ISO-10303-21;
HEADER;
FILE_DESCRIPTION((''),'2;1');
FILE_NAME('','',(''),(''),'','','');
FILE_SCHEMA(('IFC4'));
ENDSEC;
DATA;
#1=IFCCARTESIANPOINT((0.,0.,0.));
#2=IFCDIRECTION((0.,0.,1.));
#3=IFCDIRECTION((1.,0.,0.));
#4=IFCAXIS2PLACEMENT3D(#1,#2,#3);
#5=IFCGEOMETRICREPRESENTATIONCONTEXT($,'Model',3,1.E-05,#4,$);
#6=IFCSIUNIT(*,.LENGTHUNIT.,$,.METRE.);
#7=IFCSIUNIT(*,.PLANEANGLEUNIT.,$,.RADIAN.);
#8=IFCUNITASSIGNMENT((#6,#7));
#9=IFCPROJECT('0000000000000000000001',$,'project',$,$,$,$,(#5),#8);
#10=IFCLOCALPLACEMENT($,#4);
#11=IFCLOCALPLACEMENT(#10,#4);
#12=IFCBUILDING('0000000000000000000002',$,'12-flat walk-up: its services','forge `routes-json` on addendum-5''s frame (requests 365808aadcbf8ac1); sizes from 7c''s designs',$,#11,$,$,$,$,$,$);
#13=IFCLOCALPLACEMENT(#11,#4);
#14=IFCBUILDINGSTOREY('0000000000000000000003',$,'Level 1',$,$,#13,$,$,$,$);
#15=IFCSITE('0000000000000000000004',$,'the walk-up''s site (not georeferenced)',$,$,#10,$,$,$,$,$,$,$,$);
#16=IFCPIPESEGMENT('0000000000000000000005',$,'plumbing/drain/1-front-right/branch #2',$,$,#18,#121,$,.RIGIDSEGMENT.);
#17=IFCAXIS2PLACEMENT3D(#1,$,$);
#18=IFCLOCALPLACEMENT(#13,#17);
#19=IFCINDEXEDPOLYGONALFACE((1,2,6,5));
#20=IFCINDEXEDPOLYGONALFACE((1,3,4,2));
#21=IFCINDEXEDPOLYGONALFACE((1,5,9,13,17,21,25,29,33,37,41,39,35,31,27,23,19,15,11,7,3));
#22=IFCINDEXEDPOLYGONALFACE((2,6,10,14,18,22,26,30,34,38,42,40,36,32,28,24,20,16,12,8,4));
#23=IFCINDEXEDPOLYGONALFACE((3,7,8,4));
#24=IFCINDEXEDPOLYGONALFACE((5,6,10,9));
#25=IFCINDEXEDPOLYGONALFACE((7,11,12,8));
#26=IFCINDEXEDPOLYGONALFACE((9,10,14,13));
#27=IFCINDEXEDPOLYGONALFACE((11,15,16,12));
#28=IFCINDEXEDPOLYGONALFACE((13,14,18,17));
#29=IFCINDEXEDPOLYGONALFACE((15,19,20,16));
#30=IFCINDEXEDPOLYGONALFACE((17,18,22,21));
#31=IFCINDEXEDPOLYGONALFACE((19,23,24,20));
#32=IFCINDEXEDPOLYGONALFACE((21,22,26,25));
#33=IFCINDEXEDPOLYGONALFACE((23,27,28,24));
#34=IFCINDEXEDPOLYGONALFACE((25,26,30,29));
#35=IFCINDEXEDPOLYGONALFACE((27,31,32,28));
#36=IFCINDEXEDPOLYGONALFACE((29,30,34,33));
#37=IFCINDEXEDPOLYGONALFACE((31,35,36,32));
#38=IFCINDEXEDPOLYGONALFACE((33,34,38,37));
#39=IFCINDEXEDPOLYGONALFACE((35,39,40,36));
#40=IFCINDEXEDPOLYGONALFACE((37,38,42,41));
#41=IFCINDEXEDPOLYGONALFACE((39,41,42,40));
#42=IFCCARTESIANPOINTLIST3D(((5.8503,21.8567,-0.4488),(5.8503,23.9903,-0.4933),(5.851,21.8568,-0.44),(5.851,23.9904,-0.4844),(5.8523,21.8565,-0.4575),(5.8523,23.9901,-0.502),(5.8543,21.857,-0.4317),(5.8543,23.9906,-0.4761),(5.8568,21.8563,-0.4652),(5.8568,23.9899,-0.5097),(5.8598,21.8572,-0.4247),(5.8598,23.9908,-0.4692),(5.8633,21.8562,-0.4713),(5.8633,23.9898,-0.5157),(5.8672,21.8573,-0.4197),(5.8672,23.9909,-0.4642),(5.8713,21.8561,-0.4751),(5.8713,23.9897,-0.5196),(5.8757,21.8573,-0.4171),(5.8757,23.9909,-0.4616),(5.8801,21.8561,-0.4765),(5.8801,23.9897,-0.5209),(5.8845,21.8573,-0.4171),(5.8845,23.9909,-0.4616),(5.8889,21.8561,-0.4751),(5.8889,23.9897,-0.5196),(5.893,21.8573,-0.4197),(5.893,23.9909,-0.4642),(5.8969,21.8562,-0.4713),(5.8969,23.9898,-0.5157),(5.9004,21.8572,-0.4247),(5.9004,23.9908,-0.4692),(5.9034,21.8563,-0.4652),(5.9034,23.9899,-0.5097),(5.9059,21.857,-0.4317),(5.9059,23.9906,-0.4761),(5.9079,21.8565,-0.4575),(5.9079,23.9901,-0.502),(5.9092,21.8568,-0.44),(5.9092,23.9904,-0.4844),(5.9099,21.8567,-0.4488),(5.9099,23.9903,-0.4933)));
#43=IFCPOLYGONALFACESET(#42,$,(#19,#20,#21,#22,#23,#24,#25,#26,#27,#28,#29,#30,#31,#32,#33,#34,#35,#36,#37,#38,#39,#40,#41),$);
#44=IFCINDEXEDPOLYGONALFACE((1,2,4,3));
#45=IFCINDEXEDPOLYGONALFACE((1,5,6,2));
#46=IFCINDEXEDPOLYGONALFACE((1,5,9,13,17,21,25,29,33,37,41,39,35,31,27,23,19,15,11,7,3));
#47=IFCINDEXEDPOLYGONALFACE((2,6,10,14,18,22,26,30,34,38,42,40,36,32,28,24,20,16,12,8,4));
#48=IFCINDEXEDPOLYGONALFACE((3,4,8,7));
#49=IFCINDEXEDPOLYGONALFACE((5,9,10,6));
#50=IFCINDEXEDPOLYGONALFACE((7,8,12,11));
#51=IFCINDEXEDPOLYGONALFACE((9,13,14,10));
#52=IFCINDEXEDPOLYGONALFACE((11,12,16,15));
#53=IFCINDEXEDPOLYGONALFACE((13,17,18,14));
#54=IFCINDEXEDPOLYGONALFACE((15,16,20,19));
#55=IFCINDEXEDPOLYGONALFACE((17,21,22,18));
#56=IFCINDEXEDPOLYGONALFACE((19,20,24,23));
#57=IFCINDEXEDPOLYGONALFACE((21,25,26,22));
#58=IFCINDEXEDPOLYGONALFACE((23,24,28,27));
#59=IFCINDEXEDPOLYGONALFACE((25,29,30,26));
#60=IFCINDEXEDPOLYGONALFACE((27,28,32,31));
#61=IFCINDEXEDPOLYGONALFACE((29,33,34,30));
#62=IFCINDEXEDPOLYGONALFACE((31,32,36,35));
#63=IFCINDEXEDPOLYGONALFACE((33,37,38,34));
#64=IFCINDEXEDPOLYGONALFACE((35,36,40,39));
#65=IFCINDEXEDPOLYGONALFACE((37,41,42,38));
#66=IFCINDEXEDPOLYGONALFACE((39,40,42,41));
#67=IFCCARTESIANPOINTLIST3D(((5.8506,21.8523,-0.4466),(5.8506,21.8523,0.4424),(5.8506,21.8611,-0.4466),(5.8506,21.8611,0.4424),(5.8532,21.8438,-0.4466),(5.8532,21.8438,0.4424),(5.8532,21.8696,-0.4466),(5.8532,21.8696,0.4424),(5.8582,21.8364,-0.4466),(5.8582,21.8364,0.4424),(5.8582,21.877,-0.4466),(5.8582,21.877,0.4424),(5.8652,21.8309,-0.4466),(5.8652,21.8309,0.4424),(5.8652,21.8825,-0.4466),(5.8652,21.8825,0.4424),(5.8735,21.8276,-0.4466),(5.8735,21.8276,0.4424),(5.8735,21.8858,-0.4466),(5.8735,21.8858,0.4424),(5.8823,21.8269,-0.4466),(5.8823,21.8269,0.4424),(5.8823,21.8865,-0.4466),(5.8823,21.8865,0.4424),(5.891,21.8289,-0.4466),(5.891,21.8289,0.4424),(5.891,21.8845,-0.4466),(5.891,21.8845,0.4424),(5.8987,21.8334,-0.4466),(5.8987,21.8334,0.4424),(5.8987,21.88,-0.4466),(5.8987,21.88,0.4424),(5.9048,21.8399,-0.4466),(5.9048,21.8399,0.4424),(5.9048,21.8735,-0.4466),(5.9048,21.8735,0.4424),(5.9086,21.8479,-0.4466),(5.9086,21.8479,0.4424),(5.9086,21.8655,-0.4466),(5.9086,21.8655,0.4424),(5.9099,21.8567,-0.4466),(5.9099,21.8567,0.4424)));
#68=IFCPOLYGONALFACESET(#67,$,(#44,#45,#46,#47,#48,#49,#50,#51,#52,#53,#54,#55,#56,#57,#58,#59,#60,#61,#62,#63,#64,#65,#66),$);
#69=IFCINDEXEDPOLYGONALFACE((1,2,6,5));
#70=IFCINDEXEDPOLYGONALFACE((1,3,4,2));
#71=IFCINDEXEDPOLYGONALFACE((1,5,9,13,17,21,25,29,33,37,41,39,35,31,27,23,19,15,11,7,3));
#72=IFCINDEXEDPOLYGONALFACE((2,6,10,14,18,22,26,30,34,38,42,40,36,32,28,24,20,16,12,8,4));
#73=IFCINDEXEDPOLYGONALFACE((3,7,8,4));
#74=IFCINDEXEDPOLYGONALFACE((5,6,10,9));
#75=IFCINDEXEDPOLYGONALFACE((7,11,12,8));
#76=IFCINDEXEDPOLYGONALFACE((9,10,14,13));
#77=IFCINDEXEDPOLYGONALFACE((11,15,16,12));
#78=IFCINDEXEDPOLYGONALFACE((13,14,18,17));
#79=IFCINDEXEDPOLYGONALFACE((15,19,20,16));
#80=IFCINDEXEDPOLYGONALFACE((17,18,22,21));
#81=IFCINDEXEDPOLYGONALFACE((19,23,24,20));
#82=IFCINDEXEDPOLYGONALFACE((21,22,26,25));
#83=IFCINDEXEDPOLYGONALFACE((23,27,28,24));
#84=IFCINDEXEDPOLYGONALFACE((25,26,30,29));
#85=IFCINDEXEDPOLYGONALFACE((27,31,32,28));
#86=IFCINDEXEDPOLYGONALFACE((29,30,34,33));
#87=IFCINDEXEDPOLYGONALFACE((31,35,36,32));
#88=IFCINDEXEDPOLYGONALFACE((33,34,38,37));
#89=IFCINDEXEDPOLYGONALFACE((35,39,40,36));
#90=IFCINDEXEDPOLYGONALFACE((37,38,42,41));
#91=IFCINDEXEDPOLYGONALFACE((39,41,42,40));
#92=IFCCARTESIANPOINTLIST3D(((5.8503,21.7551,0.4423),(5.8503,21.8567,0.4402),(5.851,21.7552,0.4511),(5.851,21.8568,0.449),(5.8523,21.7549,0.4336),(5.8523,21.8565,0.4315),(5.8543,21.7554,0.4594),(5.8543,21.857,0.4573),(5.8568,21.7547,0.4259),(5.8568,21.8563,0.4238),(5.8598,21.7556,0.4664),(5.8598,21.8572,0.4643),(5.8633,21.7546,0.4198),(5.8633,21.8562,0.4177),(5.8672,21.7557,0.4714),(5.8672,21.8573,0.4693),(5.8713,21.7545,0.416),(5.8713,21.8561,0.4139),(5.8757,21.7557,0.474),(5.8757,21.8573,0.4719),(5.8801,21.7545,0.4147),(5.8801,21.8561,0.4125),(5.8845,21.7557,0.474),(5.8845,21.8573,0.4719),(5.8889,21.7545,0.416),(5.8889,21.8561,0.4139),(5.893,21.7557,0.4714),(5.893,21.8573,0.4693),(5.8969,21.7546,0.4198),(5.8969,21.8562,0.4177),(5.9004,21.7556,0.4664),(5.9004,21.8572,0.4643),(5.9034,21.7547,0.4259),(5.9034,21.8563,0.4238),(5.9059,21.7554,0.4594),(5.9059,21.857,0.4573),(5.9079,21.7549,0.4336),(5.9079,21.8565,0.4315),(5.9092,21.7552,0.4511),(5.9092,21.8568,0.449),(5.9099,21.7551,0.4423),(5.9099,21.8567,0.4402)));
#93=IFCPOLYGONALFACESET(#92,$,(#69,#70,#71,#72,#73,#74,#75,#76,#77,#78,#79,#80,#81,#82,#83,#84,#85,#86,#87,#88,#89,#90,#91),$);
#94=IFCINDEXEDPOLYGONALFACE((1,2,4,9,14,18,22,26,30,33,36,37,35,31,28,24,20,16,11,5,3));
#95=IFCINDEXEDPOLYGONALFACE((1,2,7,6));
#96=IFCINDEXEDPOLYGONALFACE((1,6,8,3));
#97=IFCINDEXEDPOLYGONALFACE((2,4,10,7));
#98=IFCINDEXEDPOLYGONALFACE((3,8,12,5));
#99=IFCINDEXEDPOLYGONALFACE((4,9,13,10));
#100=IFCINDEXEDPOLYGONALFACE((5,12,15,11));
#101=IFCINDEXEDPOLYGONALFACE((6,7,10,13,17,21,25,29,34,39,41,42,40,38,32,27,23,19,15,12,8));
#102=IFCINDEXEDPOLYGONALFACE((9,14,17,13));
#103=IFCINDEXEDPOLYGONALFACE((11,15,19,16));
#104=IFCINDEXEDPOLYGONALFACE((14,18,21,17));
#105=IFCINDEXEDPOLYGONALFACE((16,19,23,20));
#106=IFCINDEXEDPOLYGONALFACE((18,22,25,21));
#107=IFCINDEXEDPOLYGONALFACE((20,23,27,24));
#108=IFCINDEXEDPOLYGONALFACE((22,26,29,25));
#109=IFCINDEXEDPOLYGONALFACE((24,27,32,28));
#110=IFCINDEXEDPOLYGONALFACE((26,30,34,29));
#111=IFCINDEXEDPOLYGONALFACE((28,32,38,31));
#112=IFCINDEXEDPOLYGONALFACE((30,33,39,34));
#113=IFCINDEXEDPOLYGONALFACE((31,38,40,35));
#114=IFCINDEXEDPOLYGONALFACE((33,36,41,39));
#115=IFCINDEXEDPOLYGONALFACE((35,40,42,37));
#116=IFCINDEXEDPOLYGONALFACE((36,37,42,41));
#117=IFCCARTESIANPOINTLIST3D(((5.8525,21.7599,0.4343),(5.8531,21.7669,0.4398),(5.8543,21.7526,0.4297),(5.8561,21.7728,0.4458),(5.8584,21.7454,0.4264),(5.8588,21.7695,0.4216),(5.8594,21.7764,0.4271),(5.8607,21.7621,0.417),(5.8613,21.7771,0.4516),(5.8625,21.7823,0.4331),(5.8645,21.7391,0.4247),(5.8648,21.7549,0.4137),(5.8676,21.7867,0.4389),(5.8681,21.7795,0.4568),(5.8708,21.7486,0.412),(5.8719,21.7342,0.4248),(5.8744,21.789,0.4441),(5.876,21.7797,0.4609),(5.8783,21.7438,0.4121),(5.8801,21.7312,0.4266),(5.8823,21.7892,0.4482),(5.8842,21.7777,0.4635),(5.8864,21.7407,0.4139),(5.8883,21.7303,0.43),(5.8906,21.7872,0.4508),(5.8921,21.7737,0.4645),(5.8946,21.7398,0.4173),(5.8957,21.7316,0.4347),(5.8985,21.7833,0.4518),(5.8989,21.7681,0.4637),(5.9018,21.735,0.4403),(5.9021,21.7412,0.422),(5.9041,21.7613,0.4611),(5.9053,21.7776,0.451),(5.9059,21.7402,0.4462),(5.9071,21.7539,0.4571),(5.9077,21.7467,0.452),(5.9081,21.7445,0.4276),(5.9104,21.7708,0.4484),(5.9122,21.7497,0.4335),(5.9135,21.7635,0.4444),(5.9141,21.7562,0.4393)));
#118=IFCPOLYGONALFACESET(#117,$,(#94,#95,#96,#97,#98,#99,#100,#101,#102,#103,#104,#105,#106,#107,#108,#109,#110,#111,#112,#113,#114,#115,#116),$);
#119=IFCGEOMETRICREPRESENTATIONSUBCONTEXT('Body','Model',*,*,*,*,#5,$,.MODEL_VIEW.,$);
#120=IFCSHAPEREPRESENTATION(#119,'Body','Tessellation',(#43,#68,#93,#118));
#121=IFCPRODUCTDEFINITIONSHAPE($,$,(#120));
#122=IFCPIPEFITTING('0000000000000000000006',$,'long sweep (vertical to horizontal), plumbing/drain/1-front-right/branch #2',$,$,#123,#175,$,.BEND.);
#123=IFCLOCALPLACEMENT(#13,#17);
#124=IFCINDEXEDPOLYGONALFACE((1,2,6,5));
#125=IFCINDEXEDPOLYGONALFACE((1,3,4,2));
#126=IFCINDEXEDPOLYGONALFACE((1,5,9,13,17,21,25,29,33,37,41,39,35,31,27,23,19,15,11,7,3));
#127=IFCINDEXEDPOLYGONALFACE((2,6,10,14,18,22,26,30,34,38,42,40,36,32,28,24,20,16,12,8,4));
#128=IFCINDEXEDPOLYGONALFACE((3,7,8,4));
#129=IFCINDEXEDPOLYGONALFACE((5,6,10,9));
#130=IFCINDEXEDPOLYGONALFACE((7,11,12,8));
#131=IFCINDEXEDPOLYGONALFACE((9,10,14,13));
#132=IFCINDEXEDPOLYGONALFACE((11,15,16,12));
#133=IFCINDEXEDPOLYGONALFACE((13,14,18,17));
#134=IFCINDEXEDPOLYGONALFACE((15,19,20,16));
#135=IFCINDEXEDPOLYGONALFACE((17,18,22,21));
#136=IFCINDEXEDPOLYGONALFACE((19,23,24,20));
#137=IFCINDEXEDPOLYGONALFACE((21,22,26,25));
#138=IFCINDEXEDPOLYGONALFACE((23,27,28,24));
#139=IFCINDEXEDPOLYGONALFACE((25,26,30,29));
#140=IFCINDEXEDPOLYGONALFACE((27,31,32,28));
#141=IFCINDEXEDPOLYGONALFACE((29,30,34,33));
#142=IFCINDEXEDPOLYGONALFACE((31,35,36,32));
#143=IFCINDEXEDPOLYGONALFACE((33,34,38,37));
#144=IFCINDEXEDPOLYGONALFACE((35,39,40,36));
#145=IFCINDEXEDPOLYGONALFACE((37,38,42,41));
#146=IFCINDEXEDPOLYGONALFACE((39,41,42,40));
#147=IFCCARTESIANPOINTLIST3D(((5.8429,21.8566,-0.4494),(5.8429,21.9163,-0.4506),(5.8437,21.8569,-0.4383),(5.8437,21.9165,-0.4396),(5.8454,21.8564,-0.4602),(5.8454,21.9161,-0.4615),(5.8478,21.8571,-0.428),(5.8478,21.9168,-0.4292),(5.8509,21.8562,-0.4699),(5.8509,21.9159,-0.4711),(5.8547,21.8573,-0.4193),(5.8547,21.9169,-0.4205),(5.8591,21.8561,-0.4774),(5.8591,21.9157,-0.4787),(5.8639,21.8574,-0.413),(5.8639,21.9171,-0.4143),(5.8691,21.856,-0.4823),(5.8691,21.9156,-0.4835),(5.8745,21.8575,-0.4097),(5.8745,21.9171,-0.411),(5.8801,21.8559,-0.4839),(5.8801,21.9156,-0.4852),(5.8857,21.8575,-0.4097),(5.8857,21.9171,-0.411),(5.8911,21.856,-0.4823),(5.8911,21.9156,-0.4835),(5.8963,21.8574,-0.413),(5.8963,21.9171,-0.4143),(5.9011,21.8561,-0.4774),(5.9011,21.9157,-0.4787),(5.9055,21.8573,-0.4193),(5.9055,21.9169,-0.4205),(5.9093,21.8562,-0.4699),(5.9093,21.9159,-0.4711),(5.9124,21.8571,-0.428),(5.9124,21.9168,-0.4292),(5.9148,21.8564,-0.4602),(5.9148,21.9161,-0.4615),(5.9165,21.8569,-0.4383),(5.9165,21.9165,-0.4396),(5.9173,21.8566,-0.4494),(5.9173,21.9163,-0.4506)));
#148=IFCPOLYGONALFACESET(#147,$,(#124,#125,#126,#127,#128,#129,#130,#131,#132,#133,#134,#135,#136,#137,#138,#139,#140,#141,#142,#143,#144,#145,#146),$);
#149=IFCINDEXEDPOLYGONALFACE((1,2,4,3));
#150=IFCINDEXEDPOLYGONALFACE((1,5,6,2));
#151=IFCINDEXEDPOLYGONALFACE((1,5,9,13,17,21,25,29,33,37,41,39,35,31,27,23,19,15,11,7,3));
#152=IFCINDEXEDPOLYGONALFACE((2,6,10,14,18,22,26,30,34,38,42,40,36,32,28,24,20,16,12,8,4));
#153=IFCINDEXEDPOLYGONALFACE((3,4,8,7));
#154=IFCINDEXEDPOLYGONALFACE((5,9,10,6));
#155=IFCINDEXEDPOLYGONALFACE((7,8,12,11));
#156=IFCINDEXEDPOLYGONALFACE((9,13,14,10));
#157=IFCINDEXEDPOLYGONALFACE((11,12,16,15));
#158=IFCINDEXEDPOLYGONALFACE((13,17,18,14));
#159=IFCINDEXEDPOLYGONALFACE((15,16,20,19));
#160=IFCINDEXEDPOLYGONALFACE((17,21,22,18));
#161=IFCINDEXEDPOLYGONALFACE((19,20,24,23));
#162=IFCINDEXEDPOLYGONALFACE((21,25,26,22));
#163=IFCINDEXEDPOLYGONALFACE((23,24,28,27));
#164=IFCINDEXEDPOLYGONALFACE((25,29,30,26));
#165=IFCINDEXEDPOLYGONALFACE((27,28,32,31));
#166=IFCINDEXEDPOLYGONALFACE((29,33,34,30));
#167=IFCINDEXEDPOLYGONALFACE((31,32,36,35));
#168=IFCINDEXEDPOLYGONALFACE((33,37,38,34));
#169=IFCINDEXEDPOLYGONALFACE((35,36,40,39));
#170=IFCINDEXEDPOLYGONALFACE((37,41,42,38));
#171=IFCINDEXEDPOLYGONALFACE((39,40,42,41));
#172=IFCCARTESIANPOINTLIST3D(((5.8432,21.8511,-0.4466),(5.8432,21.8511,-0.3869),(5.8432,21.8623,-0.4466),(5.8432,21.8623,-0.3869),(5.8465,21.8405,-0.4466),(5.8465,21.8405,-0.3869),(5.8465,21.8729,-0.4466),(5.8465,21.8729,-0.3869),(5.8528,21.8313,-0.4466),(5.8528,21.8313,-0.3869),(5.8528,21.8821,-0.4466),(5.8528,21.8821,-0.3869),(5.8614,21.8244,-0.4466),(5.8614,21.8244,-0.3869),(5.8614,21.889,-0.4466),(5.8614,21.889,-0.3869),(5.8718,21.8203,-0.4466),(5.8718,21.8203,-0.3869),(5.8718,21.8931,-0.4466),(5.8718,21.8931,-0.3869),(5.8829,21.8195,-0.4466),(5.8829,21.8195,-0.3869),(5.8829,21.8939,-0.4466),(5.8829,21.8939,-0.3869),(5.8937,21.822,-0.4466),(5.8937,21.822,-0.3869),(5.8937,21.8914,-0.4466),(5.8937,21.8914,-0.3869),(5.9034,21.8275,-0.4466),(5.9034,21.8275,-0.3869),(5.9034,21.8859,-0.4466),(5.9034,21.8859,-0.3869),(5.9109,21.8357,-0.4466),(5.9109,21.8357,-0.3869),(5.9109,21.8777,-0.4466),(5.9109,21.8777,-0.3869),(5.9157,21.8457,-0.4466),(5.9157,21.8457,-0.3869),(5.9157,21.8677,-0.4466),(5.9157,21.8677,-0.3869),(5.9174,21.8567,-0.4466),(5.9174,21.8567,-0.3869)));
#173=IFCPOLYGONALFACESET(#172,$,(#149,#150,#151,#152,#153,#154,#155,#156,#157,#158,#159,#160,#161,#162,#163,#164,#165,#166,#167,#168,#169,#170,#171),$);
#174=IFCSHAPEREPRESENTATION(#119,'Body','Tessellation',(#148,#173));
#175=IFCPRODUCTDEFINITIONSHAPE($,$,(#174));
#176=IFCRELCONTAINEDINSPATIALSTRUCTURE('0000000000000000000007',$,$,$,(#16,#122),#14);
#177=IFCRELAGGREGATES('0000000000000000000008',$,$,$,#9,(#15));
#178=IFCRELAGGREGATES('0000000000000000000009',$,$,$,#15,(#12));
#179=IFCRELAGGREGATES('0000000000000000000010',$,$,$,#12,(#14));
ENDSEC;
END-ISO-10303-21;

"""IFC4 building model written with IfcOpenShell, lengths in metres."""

from ifc_helpers import new_model, entity, si_unit, frame, origin_with_axes, place, context, subcontext, project, spatial, element, save


model = new_model("IFC4")

# Units and contexts
model_context = context("Model", 3, precision=1e-05, world=origin_with_axes())
body_context = subcontext(model_context, "Body", "Model", "MODEL_VIEW")
ifc_project = project(units=[si_unit("LENGTHUNIT", "METRE"), si_unit("PLANEANGLEUNIT", "RADIAN")], contexts=[model_context])

# Site, building, storey
site_placement = place(None, origin_with_axes())
site = spatial("IfcSite", under=ifc_project, at=site_placement, Name="the walk-up's site (not georeferenced)")
building_placement = place(site_placement, origin_with_axes())
building = spatial("IfcBuilding", under=site, at=building_placement, Name="12-flat walk-up: its services", Description="forge `routes-json` on addendum-5's frame (requests 365808aadcbf8ac1); sizes from 7c's designs")
storey_placement = place(building_placement, origin_with_axes())
storey = spatial("IfcBuildingStorey", under=building, at=storey_placement, Name="Level 1")

# Pipe segment
pipe_segment_1_placement = place(storey_placement, frame((5.8801, 23.9903, -0.4911), z_axis=(0.0, 0.0, 1.0), x_axis=(1.0, 0.0, 0.0)))
element("IfcPipeSegment", 1, at=pipe_segment_1_placement, inside=storey, Name="plumbing/drain/1-front-right/branch #2", PredefinedType="RIGIDSEGMENT", context=body_context, shape_type="AdvancedSweptSolid", body=[
    entity("IfcSweptDiskSolid", entity("IfcPolyline", [entity("IfcCartesianPoint", [0.0, 0.0, 0.0]), entity("IfcCartesianPoint", [0.0, -2.1336, 0.0444])]), 0.0298),
    entity("IfcSweptDiskSolid", entity("IfcPolyline", [entity("IfcCartesianPoint", [0.0, -2.1336, 0.0444]), entity("IfcCartesianPoint", [0.0, -2.1336, 0.9334])]), 0.0298),
    entity("IfcSweptDiskSolid", entity("IfcPolyline", [entity("IfcCartesianPoint", [0.0, -2.1336, 0.9334]), entity("IfcCartesianPoint", [0.0, -2.2352, 0.9356])]), 0.0298),
    entity("IfcSweptDiskSolid", entity("IfcPolyline", [entity("IfcCartesianPoint", [0.0, -2.2352, 0.9356]), entity("IfcCartesianPoint", [0.0064, -2.2257, 0.9229])]), 0.0298),
])

# Pipe fitting
pipe_fitting_1_placement = place(storey_placement, frame((5.8801, 21.9164, -0.4479), z_axis=(0.0, 0.0, 1.0), x_axis=(1.0, 0.0, 0.0)))
element("IfcPipeFitting", 2, at=pipe_fitting_1_placement, inside=storey, Name="long sweep (vertical to horizontal), plumbing/drain/1-front-right/branch #2", PredefinedType="BEND", context=body_context, shape_type="AdvancedSweptSolid", body=[
    entity("IfcSweptDiskSolid", entity("IfcPolyline", [entity("IfcCartesianPoint", [0.0, 0.0, 0.0]), entity("IfcCartesianPoint", [0.0, -0.0597, 0.0012])]), 0.0373),
    entity("IfcSweptDiskSolid", entity("IfcPolyline", [entity("IfcCartesianPoint", [0.0, -0.0597, 0.0012]), entity("IfcCartesianPoint", [0.0, -0.0597, 0.0609])]), 0.0373),
])

save(model, "model.ifc")
